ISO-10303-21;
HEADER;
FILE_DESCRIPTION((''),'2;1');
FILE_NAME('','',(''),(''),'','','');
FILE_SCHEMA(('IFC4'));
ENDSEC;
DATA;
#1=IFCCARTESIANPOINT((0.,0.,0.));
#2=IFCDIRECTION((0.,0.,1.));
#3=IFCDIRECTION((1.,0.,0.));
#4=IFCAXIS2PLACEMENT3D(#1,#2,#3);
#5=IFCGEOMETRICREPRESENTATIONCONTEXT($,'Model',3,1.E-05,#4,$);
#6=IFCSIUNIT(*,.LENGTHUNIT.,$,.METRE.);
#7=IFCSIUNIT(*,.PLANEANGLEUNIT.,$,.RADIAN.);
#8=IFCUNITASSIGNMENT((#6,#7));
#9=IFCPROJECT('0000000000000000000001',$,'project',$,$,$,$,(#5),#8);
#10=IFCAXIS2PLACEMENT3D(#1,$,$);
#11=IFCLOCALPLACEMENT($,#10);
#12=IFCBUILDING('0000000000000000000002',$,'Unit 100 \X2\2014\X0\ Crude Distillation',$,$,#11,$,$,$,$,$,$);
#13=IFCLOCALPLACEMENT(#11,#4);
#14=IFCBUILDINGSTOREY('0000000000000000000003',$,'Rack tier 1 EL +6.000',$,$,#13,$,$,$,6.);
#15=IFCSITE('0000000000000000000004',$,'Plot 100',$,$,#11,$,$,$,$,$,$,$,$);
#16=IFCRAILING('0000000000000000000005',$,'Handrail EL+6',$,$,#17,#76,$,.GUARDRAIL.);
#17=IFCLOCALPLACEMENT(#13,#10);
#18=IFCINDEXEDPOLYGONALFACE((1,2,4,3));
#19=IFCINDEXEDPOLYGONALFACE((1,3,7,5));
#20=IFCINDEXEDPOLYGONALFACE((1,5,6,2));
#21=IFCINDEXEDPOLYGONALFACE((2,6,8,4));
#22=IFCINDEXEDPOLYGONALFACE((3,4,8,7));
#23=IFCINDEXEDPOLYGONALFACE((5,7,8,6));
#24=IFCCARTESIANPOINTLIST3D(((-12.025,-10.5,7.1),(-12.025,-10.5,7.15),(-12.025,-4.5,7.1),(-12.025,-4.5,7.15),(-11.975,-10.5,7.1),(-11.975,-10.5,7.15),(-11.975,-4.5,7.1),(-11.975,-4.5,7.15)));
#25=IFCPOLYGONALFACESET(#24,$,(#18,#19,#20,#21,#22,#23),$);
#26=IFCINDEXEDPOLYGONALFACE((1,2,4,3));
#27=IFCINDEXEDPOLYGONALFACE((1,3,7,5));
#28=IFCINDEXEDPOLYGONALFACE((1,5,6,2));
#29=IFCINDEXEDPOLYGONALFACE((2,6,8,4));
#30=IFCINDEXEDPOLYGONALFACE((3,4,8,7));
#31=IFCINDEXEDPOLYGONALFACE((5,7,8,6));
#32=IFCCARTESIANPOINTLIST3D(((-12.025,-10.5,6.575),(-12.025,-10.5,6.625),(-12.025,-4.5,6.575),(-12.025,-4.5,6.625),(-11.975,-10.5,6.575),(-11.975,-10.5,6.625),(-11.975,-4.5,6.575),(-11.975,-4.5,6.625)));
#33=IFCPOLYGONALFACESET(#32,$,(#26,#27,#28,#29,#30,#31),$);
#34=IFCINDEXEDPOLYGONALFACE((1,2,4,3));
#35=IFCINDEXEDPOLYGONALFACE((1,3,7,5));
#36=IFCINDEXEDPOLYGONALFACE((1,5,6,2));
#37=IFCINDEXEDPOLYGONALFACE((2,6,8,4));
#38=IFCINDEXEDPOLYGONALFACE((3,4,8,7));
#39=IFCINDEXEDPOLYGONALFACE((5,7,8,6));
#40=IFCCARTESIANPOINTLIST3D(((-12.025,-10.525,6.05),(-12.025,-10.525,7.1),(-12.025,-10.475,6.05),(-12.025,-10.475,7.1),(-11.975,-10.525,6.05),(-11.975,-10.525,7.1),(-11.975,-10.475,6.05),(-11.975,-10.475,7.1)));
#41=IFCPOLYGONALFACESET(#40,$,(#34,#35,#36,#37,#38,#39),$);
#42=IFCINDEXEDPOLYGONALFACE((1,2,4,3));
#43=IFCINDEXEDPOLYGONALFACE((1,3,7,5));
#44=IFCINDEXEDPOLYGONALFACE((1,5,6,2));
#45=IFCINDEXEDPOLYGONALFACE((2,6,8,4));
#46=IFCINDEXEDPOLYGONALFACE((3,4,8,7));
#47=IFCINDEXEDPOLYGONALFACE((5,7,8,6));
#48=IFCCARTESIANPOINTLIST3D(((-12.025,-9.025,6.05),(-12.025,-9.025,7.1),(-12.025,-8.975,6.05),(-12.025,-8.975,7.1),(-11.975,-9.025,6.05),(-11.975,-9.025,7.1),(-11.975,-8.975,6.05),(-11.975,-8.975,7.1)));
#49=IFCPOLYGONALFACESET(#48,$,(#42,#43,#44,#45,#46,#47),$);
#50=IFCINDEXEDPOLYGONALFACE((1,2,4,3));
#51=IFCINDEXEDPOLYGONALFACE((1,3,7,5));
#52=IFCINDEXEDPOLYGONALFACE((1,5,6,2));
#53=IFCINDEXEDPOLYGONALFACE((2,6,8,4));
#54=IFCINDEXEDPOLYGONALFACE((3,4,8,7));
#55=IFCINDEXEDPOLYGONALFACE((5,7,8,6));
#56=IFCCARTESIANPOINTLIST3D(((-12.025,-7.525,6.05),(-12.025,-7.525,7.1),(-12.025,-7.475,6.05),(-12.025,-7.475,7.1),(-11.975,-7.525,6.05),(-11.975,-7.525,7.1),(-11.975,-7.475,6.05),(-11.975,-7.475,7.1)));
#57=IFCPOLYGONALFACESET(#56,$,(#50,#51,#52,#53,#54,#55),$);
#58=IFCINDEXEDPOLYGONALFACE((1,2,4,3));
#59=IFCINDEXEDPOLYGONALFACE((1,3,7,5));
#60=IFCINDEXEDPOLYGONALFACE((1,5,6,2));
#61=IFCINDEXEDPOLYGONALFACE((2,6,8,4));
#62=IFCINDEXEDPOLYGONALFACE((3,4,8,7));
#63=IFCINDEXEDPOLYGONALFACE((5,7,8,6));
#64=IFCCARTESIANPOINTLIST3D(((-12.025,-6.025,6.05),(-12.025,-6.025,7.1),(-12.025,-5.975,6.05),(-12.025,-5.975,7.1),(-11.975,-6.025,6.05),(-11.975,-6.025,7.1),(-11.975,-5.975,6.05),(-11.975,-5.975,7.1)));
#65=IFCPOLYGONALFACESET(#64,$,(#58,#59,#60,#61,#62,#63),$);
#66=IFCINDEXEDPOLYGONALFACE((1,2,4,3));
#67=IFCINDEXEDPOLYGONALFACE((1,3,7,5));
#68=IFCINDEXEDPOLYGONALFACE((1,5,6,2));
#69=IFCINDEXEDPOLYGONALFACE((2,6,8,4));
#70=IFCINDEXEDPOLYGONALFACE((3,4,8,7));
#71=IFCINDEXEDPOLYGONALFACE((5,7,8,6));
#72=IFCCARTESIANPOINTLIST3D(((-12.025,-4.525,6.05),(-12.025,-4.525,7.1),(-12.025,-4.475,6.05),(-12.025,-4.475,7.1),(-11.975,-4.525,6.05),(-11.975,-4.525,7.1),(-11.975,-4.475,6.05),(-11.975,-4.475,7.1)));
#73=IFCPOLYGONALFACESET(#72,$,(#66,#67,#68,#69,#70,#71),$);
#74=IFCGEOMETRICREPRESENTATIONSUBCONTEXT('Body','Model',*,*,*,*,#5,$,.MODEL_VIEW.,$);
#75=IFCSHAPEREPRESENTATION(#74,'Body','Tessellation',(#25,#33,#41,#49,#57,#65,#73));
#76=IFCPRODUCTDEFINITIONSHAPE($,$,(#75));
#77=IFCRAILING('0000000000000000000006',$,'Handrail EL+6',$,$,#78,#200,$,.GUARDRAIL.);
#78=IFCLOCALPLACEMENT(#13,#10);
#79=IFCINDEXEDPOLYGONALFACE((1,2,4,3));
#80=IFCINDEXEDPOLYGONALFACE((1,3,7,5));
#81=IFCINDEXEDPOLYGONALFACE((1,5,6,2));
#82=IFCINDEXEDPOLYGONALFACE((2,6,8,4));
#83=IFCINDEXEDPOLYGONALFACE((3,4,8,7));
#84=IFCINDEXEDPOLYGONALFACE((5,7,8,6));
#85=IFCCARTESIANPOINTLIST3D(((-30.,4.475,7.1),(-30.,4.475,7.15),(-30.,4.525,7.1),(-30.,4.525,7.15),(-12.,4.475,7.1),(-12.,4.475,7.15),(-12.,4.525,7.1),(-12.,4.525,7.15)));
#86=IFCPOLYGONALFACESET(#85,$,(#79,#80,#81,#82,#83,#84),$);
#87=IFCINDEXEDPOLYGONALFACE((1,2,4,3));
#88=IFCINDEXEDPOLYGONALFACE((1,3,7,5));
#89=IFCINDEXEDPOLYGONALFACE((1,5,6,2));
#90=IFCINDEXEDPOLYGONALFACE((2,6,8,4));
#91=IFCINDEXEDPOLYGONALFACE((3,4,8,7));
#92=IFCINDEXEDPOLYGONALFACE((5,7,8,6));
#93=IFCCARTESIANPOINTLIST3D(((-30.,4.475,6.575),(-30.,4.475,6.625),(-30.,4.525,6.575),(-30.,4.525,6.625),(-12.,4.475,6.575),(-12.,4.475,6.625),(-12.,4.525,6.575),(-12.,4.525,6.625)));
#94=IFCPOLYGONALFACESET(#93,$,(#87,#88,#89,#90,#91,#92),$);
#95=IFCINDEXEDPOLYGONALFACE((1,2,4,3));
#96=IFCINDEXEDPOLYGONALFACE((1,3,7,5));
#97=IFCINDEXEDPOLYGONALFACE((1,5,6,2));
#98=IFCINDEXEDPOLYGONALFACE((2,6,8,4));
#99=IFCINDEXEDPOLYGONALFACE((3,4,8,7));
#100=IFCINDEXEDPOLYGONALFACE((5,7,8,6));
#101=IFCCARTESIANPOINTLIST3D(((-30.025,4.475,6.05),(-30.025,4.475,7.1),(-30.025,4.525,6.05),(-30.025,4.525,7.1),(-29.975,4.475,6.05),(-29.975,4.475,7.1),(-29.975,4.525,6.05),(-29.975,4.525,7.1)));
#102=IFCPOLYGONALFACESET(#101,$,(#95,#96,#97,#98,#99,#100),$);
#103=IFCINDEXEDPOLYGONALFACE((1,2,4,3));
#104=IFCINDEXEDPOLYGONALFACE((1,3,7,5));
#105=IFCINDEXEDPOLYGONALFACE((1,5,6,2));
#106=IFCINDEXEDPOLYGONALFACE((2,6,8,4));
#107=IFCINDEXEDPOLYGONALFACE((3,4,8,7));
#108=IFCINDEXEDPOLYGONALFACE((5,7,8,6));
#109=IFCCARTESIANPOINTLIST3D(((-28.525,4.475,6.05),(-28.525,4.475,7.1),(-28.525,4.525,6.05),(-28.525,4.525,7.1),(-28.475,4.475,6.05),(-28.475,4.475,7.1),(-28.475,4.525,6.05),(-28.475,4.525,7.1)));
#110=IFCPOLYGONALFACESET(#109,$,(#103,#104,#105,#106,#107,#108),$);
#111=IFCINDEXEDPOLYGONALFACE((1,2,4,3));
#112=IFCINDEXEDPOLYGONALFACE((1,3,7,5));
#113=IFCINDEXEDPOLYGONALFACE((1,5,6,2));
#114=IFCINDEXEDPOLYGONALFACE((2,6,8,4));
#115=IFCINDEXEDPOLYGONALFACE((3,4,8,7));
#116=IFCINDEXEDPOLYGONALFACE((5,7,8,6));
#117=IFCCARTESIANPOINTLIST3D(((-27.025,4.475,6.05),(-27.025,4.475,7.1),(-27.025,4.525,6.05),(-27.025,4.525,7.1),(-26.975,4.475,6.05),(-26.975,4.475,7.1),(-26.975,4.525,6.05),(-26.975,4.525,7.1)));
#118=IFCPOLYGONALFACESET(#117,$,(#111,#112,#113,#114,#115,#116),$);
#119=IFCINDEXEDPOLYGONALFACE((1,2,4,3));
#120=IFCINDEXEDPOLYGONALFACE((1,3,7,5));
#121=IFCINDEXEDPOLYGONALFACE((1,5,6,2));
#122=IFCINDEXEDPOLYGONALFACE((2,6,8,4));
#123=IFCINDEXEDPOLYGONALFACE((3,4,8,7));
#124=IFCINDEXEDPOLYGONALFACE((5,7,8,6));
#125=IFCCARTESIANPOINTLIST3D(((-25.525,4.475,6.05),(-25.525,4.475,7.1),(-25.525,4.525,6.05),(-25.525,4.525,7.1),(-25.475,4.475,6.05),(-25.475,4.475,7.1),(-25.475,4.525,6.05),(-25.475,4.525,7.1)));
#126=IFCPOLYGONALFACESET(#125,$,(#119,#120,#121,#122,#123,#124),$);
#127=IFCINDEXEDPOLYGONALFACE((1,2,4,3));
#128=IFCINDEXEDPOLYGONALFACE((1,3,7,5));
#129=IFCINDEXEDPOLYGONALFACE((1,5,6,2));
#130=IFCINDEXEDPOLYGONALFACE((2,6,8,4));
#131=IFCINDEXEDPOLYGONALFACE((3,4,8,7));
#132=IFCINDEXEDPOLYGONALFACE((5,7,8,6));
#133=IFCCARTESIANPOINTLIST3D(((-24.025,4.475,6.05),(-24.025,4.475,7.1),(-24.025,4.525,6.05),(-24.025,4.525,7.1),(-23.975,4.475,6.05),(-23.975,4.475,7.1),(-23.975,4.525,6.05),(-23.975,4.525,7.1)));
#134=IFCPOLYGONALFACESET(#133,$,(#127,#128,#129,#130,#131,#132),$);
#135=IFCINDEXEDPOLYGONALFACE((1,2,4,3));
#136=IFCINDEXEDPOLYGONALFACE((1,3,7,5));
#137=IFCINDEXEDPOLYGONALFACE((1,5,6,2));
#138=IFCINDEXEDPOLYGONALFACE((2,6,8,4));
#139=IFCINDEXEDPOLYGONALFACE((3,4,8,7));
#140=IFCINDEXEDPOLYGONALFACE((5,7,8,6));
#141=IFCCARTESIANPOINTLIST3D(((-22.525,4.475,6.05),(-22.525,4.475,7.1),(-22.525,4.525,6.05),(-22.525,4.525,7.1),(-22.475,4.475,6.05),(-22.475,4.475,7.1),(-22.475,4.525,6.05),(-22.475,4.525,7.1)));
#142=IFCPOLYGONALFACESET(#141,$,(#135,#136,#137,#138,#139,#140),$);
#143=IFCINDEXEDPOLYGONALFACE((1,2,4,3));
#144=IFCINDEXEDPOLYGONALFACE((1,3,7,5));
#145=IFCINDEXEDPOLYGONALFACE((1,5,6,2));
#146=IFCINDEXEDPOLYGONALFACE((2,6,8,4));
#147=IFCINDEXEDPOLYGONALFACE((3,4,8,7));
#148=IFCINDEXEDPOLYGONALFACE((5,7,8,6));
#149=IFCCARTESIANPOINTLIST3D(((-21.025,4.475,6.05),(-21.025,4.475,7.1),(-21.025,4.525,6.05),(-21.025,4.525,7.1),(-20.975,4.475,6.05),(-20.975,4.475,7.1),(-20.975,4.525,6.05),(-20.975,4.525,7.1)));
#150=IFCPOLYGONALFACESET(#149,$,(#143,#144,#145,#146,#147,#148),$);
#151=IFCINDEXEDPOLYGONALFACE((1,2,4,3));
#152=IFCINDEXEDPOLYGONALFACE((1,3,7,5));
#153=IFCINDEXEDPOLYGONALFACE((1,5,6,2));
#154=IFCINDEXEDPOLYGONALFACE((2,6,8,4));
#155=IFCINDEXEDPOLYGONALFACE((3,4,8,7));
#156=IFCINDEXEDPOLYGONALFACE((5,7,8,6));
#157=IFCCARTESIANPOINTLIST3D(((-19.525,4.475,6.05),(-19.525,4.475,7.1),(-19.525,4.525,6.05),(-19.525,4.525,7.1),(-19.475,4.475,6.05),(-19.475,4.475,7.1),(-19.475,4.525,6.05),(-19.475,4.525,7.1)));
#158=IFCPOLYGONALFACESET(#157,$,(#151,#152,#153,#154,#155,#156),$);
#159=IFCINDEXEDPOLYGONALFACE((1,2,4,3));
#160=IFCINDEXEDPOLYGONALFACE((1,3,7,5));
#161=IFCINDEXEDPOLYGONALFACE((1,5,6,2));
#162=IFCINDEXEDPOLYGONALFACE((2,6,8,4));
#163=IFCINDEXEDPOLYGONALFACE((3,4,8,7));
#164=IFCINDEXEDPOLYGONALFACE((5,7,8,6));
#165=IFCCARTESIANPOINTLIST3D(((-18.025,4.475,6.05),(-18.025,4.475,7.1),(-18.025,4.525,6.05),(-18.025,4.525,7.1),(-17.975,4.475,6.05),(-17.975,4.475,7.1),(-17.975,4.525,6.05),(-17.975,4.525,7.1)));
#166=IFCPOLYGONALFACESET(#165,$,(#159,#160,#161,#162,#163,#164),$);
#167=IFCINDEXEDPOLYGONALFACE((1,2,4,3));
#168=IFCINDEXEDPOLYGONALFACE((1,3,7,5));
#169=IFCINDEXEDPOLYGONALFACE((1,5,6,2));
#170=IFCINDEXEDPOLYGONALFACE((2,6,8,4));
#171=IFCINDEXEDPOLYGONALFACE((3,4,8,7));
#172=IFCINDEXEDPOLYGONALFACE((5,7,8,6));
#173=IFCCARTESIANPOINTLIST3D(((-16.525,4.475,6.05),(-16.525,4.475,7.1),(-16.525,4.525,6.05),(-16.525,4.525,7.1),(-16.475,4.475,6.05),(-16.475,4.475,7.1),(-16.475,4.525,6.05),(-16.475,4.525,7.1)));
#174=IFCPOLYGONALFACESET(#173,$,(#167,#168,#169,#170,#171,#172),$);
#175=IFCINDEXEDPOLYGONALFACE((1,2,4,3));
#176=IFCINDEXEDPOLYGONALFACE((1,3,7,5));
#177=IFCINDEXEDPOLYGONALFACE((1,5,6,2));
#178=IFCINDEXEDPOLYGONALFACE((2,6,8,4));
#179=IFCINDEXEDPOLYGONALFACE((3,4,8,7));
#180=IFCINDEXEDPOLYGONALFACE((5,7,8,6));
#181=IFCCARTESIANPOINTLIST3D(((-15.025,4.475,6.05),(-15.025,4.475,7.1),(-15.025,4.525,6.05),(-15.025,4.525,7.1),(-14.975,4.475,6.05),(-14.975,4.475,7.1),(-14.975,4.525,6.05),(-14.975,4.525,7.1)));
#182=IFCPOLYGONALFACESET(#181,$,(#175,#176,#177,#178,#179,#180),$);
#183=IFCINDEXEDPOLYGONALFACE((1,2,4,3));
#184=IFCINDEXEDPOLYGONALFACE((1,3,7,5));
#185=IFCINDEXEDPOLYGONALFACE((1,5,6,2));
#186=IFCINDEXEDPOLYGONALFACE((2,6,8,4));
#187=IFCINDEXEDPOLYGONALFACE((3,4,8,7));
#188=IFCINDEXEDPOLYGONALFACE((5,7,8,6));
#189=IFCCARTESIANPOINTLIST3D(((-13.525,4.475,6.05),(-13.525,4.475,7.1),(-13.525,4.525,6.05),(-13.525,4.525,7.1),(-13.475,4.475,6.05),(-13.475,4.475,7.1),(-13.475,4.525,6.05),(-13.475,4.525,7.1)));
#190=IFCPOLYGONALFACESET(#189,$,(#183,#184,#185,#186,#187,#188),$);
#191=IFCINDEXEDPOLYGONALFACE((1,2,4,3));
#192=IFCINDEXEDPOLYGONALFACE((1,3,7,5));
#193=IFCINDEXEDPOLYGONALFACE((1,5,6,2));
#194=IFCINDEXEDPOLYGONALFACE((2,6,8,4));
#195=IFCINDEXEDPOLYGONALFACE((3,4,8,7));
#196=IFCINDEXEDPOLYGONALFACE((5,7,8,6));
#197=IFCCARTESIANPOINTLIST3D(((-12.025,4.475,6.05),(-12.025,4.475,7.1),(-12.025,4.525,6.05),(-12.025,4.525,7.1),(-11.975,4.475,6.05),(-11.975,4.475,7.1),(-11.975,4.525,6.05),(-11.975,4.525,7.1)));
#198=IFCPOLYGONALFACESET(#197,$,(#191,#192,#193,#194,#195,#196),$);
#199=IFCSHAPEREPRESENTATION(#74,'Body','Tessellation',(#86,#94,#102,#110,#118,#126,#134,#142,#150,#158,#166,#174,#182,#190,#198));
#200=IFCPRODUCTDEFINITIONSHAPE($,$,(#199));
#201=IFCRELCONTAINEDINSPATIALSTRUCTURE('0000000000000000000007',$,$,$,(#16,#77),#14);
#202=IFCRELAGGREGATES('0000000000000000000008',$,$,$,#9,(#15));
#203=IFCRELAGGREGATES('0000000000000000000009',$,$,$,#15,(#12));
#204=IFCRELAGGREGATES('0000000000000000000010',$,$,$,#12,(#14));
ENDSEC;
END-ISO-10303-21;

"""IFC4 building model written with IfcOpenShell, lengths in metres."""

from ifc_helpers import new_model, si_unit, frame, origin, origin_with_axes, origin_2d, place, context, subcontext, project, spatial, rectangle, extrude, element, save


model = new_model("IFC4")

# Units and contexts
model_context = context("Model", 3, precision=1e-05, world=origin_with_axes())
body_context = subcontext(model_context, "Body", "Model", "MODEL_VIEW")
ifc_project = project(units=[si_unit("LENGTHUNIT", "METRE"), si_unit("PLANEANGLEUNIT", "RADIAN")], contexts=[model_context])

# Site, building, storey
placement = place(None, origin())
site = spatial("IfcSite", under=ifc_project, at=placement, Name="Plot 100")
building = spatial("IfcBuilding", under=site, at=placement, Name="Unit 100 — Crude Distillation")
storey_placement = place(placement, origin_with_axes())
storey = spatial("IfcBuildingStorey", under=building, at=storey_placement, Name="Rack tier 1 EL +6.000", Elevation=6.0)

# Railings
railing_1_placement = place(storey_placement, origin_with_axes())
element("IfcRailing", 1, at=railing_1_placement, inside=storey, Name="Handrail EL+6", PredefinedType="GUARDRAIL", context=body_context, shape_type="SweptSolid", body=[
    extrude(rectangle(XDim=0.05, YDim=0.05, at=origin_2d()), frame((-12.0, -10.5, 7.125), z_axis=(0.0, 1.0, 0.0), x_axis=(-1.0, 0.0, 0.0)), (0.0, 0.0, 1.0), 6.0),
    extrude(rectangle(XDim=0.05, YDim=0.05, at=origin_2d()), frame((-12.0, -10.5, 6.6), z_axis=(0.0, 1.0, 0.0), x_axis=(-1.0, 0.0, 0.0)), (0.0, 0.0, 1.0), 6.0),
    extrude(rectangle(XDim=0.05, YDim=0.05, at=origin_2d()), frame((-12.0, -10.5, 6.05), z_axis=(0.0, 0.0, 1.0), x_axis=(1.0, 0.0, 0.0)), (0.0, 0.0, 1.0), 1.05),
    extrude(rectangle(XDim=0.05, YDim=0.05, at=origin_2d()), frame((-12.0, -9.0, 6.05), z_axis=(0.0, 0.0, 1.0), x_axis=(1.0, 0.0, 0.0)), (0.0, 0.0, 1.0), 1.05),
    extrude(rectangle(XDim=0.05, YDim=0.05, at=origin_2d()), frame((-12.0, -7.5, 6.05), z_axis=(0.0, 0.0, 1.0), x_axis=(1.0, 0.0, 0.0)), (0.0, 0.0, 1.0), 1.05),
    extrude(rectangle(XDim=0.05, YDim=0.05, at=origin_2d()), frame((-12.0, -6.0, 6.05), z_axis=(0.0, 0.0, 1.0), x_axis=(1.0, 0.0, 0.0)), (0.0, 0.0, 1.0), 1.05),
    extrude(rectangle(XDim=0.05, YDim=0.05, at=origin_2d()), frame((-12.0, -4.5, 6.05), z_axis=(0.0, 0.0, 1.0), x_axis=(1.0, 0.0, 0.0)), (0.0, 0.0, 1.0), 1.05),
])
railing_2_placement = place(storey_placement, origin_with_axes())
element("IfcRailing", 2, at=railing_2_placement, inside=storey, Name="Handrail EL+6", PredefinedType="GUARDRAIL", context=body_context, shape_type="SweptSolid", body=[
    extrude(rectangle(XDim=0.05, YDim=0.05, at=origin_2d()), frame((-30.0, 4.5, 7.125), z_axis=(1.0, 0.0, 0.0), x_axis=(0.0, 1.0, 0.0)), (0.0, 0.0, 1.0), 18.0),
    extrude(rectangle(XDim=0.05, YDim=0.05, at=origin_2d()), frame((-30.0, 4.5, 6.6), z_axis=(1.0, 0.0, 0.0), x_axis=(0.0, 1.0, 0.0)), (0.0, 0.0, 1.0), 18.0),
    extrude(rectangle(XDim=0.05, YDim=0.05, at=origin_2d()), frame((-30.0, 4.5, 6.05), z_axis=(0.0, 0.0, 1.0), x_axis=(1.0, 0.0, 0.0)), (0.0, 0.0, 1.0), 1.05),
    extrude(rectangle(XDim=0.05, YDim=0.05, at=origin_2d()), frame((-28.5, 4.5, 6.05), z_axis=(0.0, 0.0, 1.0), x_axis=(1.0, 0.0, 0.0)), (0.0, 0.0, 1.0), 1.05),
    extrude(rectangle(XDim=0.05, YDim=0.05, at=origin_2d()), frame((-27.0, 4.5, 6.05), z_axis=(0.0, 0.0, 1.0), x_axis=(1.0, 0.0, 0.0)), (0.0, 0.0, 1.0), 1.05),
    extrude(rectangle(XDim=0.05, YDim=0.05, at=origin_2d()), frame((-25.5, 4.5, 6.05), z_axis=(0.0, 0.0, 1.0), x_axis=(1.0, 0.0, 0.0)), (0.0, 0.0, 1.0), 1.05),
    extrude(rectangle(XDim=0.05, YDim=0.05, at=origin_2d()), frame((-24.0, 4.5, 6.05), z_axis=(0.0, 0.0, 1.0), x_axis=(1.0, 0.0, 0.0)), (0.0, 0.0, 1.0), 1.05),
    extrude(rectangle(XDim=0.05, YDim=0.05, at=origin_2d()), frame((-22.5, 4.5, 6.05), z_axis=(0.0, 0.0, 1.0), x_axis=(1.0, 0.0, 0.0)), (0.0, 0.0, 1.0), 1.05),
    extrude(rectangle(XDim=0.05, YDim=0.05, at=origin_2d()), frame((-21.0, 4.5, 6.05), z_axis=(0.0, 0.0, 1.0), x_axis=(1.0, 0.0, 0.0)), (0.0, 0.0, 1.0), 1.05),
    extrude(rectangle(XDim=0.05, YDim=0.05, at=origin_2d()), frame((-19.5, 4.5, 6.05), z_axis=(0.0, 0.0, 1.0), x_axis=(1.0, 0.0, 0.0)), (0.0, 0.0, 1.0), 1.05),
    extrude(rectangle(XDim=0.05, YDim=0.05, at=origin_2d()), frame((-18.0, 4.5, 6.05), z_axis=(0.0, 0.0, 1.0), x_axis=(1.0, 0.0, 0.0)), (0.0, 0.0, 1.0), 1.05),
    extrude(rectangle(XDim=0.05, YDim=0.05, at=origin_2d()), frame((-16.5, 4.5, 6.05), z_axis=(0.0, 0.0, 1.0), x_axis=(1.0, 0.0, 0.0)), (0.0, 0.0, 1.0), 1.05),
    extrude(rectangle(XDim=0.05, YDim=0.05, at=origin_2d()), frame((-15.0, 4.5, 6.05), z_axis=(0.0, 0.0, 1.0), x_axis=(1.0, 0.0, 0.0)), (0.0, 0.0, 1.0), 1.05),
    extrude(rectangle(XDim=0.05, YDim=0.05, at=origin_2d()), frame((-13.5, 4.5, 6.05), z_axis=(0.0, 0.0, 1.0), x_axis=(1.0, 0.0, 0.0)), (0.0, 0.0, 1.0), 1.05),
    extrude(rectangle(XDim=0.05, YDim=0.05, at=origin_2d()), frame((-12.0, 4.5, 6.05), z_axis=(0.0, 0.0, 1.0), x_axis=(1.0, 0.0, 0.0)), (0.0, 0.0, 1.0), 1.05),
])

save(model, "model.ifc")
